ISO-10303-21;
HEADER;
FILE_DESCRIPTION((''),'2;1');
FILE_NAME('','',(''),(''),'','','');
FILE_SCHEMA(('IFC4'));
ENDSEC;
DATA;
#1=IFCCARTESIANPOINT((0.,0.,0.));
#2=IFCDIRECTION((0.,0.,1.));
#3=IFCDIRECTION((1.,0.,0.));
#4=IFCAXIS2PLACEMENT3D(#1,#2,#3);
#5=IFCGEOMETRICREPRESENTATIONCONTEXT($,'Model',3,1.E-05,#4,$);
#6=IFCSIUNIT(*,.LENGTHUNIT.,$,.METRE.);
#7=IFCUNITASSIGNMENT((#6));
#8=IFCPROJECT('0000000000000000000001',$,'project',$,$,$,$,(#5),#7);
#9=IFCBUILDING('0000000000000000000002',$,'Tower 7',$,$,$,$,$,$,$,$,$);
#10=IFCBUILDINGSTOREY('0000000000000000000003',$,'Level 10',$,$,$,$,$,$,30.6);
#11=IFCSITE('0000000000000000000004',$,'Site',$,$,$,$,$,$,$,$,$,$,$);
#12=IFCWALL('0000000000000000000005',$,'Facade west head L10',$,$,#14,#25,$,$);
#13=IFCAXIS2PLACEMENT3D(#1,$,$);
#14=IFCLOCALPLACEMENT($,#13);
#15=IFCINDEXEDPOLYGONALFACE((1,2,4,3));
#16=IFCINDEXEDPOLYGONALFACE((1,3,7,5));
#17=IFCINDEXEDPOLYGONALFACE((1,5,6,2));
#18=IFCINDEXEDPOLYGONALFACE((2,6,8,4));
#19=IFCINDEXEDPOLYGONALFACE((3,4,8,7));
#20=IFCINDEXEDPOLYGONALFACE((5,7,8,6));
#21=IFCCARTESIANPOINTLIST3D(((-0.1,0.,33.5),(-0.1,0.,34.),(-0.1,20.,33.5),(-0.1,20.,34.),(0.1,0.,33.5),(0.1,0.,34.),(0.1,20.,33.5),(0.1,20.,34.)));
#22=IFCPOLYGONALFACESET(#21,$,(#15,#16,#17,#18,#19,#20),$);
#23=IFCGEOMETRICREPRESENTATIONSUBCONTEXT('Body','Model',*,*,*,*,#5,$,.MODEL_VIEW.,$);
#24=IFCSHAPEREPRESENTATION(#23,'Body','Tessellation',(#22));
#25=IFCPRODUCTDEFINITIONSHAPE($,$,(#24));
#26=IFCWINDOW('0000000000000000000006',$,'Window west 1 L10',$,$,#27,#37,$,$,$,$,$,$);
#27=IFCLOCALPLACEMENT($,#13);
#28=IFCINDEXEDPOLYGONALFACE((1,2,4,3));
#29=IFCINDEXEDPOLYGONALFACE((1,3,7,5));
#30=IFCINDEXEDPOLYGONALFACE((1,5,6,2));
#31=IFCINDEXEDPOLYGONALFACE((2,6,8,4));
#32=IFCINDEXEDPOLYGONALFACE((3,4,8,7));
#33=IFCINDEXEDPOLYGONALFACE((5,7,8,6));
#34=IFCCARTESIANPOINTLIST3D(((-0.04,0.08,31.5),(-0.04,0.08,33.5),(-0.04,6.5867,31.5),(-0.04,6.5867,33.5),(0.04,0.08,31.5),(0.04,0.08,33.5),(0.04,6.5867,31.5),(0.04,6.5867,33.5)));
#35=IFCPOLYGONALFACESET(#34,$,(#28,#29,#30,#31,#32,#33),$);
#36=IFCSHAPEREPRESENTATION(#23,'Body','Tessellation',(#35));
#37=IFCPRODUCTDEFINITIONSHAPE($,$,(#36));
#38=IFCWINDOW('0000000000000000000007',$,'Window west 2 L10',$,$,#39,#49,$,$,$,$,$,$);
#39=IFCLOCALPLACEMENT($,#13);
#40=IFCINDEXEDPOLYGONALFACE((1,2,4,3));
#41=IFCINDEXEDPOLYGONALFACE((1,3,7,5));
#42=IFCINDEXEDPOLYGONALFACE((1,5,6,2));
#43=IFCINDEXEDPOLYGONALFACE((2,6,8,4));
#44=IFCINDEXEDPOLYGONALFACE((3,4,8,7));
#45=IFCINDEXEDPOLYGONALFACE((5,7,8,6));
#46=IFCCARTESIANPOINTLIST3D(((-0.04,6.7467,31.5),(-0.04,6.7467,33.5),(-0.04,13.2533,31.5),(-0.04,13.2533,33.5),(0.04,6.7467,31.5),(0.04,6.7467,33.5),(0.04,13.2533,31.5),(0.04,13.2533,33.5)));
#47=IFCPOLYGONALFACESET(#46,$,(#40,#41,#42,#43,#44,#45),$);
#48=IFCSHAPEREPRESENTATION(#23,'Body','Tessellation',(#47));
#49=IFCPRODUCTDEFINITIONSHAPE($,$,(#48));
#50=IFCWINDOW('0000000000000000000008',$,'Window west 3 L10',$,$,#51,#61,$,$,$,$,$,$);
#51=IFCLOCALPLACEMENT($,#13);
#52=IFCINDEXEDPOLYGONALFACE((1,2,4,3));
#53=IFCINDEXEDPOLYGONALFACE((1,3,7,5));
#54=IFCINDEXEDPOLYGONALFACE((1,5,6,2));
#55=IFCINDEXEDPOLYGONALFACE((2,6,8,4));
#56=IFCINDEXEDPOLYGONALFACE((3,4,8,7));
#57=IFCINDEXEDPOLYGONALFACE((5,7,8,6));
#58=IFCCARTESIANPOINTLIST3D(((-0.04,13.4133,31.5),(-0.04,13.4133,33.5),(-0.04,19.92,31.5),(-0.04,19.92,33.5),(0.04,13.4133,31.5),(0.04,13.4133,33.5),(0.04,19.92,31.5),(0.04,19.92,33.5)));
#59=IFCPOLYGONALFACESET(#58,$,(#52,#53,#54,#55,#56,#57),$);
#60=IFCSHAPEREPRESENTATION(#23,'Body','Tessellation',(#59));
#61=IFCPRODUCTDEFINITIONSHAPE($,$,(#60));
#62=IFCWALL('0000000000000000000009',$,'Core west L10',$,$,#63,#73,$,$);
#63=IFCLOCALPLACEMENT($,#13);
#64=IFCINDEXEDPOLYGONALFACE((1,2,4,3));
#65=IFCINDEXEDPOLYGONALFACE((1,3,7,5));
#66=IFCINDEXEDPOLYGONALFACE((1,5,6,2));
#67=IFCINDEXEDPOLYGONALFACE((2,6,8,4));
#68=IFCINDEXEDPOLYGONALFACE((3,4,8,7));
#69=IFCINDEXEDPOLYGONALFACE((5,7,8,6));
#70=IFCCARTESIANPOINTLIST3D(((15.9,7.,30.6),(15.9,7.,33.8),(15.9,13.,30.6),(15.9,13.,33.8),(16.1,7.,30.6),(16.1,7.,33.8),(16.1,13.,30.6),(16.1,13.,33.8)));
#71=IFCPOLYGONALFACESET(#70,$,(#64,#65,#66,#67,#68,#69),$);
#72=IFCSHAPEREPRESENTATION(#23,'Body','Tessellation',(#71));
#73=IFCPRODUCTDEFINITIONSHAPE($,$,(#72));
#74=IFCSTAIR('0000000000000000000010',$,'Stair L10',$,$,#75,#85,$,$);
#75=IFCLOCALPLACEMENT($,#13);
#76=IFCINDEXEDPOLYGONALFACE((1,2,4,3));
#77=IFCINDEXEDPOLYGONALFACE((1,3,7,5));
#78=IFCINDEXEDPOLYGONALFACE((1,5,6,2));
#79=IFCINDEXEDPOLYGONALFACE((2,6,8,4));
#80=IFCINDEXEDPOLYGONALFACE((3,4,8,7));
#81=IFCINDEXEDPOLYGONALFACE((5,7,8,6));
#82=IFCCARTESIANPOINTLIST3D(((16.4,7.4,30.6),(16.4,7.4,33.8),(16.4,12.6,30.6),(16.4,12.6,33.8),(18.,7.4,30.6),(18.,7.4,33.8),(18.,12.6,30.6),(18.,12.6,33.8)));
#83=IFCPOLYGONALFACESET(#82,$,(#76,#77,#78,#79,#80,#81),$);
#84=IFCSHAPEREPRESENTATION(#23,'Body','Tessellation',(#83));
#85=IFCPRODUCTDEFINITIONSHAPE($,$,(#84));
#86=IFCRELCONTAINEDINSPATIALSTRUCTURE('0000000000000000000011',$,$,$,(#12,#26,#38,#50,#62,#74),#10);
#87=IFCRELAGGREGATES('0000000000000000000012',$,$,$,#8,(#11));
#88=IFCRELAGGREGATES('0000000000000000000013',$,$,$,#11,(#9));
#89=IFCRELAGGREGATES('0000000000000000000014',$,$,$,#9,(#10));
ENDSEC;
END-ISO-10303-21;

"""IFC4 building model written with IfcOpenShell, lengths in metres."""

from ifc_helpers import new_model, si_unit, frame, origin, origin_with_axes, origin_2d, place, context, subcontext, project, spatial, rectangle, extrude, element, save


model = new_model("IFC4")

# Units and contexts
model_context = context("Model", 3, precision=1e-05, world=origin_with_axes())
body_context = subcontext(model_context, "Body", "Model", "MODEL_VIEW")
ifc_project = project(units=[si_unit("LENGTHUNIT", "METRE")], contexts=[model_context])

# Site, building, storey
site = spatial("IfcSite", under=ifc_project, Name="Site")
building = spatial("IfcBuilding", under=site, Name="Tower 7")
storey = spatial("IfcBuildingStorey", under=building, Name="Level 10", Elevation=30.6)

# Wall
wall_1_placement = place(None, frame((0.0, 10.0, 33.5), z_axis=(0.0, 0.0, 1.0), x_axis=(1.0, 0.0, 0.0)))
element("IfcWall", 1, at=wall_1_placement, inside=storey, Name="Facade west head L10", context=body_context, shape_type="SweptSolid", body=[
    extrude(rectangle(XDim=0.2, YDim=20.0, at=origin_2d()), origin(), (0.0, 0.0, 1.0), 0.5),
])

# Windows
for number, where, z_axis, x_axis, name in (
    (2, (0.0, 3.3333, 31.5), (0.0, 0.0, 1.0), (1.0, 0.0, 0.0), "Window west 1 L10"),
    (3, (0.0, 10.0, 31.5), (0.0, 0.0, 1.0), (1.0, 0.0, 0.0), "Window west 2 L10"),
):
    element("IfcWindow", number, at=place(None, frame(where, z_axis=z_axis, x_axis=x_axis)), inside=storey, Name=name, context=body_context, shape_type="SweptSolid", body=[
        extrude(rectangle(XDim=0.08, YDim=6.5067, at=origin_2d()), origin(), (0.0, 0.0, 1.0), 2.0),
    ])
window_1_placement = place(None, frame((0.0, 16.6667, 31.5), z_axis=(0.0, 0.0, 1.0), x_axis=(1.0, 0.0, 0.0)))
element("IfcWindow", 4, at=window_1_placement, inside=storey, Name="Window west 3 L10", context=body_context, shape_type="SweptSolid", body=[
    extrude(rectangle(XDim=0.08, YDim=6.5067, at=origin_2d()), origin(), (0.0, 0.0, 1.0), 2.0),
])

# Wall
wall_2_placement = place(None, frame((16.0, 10.0, 30.6), z_axis=(0.0, 0.0, 1.0), x_axis=(1.0, 0.0, 0.0)))
element("IfcWall", 5, at=wall_2_placement, inside=storey, Name="Core west L10", context=body_context, shape_type="SweptSolid", body=[
    extrude(rectangle(XDim=0.2, YDim=6.0, at=origin_2d()), origin(), (0.0, 0.0, 1.0), 3.2),
])

# Stair
stair_placement = place(None, frame((17.2, 10.0, 30.6), z_axis=(0.0, 0.0, 1.0), x_axis=(1.0, 0.0, 0.0)))
element("IfcStair", 6, at=stair_placement, inside=storey, Name="Stair L10", context=body_context, shape_type="SweptSolid", body=[
    extrude(rectangle(XDim=1.6, YDim=5.2, at=origin_2d()), origin(), (0.0, 0.0, 1.0), 3.2),
])

save(model, "model.ifc")
